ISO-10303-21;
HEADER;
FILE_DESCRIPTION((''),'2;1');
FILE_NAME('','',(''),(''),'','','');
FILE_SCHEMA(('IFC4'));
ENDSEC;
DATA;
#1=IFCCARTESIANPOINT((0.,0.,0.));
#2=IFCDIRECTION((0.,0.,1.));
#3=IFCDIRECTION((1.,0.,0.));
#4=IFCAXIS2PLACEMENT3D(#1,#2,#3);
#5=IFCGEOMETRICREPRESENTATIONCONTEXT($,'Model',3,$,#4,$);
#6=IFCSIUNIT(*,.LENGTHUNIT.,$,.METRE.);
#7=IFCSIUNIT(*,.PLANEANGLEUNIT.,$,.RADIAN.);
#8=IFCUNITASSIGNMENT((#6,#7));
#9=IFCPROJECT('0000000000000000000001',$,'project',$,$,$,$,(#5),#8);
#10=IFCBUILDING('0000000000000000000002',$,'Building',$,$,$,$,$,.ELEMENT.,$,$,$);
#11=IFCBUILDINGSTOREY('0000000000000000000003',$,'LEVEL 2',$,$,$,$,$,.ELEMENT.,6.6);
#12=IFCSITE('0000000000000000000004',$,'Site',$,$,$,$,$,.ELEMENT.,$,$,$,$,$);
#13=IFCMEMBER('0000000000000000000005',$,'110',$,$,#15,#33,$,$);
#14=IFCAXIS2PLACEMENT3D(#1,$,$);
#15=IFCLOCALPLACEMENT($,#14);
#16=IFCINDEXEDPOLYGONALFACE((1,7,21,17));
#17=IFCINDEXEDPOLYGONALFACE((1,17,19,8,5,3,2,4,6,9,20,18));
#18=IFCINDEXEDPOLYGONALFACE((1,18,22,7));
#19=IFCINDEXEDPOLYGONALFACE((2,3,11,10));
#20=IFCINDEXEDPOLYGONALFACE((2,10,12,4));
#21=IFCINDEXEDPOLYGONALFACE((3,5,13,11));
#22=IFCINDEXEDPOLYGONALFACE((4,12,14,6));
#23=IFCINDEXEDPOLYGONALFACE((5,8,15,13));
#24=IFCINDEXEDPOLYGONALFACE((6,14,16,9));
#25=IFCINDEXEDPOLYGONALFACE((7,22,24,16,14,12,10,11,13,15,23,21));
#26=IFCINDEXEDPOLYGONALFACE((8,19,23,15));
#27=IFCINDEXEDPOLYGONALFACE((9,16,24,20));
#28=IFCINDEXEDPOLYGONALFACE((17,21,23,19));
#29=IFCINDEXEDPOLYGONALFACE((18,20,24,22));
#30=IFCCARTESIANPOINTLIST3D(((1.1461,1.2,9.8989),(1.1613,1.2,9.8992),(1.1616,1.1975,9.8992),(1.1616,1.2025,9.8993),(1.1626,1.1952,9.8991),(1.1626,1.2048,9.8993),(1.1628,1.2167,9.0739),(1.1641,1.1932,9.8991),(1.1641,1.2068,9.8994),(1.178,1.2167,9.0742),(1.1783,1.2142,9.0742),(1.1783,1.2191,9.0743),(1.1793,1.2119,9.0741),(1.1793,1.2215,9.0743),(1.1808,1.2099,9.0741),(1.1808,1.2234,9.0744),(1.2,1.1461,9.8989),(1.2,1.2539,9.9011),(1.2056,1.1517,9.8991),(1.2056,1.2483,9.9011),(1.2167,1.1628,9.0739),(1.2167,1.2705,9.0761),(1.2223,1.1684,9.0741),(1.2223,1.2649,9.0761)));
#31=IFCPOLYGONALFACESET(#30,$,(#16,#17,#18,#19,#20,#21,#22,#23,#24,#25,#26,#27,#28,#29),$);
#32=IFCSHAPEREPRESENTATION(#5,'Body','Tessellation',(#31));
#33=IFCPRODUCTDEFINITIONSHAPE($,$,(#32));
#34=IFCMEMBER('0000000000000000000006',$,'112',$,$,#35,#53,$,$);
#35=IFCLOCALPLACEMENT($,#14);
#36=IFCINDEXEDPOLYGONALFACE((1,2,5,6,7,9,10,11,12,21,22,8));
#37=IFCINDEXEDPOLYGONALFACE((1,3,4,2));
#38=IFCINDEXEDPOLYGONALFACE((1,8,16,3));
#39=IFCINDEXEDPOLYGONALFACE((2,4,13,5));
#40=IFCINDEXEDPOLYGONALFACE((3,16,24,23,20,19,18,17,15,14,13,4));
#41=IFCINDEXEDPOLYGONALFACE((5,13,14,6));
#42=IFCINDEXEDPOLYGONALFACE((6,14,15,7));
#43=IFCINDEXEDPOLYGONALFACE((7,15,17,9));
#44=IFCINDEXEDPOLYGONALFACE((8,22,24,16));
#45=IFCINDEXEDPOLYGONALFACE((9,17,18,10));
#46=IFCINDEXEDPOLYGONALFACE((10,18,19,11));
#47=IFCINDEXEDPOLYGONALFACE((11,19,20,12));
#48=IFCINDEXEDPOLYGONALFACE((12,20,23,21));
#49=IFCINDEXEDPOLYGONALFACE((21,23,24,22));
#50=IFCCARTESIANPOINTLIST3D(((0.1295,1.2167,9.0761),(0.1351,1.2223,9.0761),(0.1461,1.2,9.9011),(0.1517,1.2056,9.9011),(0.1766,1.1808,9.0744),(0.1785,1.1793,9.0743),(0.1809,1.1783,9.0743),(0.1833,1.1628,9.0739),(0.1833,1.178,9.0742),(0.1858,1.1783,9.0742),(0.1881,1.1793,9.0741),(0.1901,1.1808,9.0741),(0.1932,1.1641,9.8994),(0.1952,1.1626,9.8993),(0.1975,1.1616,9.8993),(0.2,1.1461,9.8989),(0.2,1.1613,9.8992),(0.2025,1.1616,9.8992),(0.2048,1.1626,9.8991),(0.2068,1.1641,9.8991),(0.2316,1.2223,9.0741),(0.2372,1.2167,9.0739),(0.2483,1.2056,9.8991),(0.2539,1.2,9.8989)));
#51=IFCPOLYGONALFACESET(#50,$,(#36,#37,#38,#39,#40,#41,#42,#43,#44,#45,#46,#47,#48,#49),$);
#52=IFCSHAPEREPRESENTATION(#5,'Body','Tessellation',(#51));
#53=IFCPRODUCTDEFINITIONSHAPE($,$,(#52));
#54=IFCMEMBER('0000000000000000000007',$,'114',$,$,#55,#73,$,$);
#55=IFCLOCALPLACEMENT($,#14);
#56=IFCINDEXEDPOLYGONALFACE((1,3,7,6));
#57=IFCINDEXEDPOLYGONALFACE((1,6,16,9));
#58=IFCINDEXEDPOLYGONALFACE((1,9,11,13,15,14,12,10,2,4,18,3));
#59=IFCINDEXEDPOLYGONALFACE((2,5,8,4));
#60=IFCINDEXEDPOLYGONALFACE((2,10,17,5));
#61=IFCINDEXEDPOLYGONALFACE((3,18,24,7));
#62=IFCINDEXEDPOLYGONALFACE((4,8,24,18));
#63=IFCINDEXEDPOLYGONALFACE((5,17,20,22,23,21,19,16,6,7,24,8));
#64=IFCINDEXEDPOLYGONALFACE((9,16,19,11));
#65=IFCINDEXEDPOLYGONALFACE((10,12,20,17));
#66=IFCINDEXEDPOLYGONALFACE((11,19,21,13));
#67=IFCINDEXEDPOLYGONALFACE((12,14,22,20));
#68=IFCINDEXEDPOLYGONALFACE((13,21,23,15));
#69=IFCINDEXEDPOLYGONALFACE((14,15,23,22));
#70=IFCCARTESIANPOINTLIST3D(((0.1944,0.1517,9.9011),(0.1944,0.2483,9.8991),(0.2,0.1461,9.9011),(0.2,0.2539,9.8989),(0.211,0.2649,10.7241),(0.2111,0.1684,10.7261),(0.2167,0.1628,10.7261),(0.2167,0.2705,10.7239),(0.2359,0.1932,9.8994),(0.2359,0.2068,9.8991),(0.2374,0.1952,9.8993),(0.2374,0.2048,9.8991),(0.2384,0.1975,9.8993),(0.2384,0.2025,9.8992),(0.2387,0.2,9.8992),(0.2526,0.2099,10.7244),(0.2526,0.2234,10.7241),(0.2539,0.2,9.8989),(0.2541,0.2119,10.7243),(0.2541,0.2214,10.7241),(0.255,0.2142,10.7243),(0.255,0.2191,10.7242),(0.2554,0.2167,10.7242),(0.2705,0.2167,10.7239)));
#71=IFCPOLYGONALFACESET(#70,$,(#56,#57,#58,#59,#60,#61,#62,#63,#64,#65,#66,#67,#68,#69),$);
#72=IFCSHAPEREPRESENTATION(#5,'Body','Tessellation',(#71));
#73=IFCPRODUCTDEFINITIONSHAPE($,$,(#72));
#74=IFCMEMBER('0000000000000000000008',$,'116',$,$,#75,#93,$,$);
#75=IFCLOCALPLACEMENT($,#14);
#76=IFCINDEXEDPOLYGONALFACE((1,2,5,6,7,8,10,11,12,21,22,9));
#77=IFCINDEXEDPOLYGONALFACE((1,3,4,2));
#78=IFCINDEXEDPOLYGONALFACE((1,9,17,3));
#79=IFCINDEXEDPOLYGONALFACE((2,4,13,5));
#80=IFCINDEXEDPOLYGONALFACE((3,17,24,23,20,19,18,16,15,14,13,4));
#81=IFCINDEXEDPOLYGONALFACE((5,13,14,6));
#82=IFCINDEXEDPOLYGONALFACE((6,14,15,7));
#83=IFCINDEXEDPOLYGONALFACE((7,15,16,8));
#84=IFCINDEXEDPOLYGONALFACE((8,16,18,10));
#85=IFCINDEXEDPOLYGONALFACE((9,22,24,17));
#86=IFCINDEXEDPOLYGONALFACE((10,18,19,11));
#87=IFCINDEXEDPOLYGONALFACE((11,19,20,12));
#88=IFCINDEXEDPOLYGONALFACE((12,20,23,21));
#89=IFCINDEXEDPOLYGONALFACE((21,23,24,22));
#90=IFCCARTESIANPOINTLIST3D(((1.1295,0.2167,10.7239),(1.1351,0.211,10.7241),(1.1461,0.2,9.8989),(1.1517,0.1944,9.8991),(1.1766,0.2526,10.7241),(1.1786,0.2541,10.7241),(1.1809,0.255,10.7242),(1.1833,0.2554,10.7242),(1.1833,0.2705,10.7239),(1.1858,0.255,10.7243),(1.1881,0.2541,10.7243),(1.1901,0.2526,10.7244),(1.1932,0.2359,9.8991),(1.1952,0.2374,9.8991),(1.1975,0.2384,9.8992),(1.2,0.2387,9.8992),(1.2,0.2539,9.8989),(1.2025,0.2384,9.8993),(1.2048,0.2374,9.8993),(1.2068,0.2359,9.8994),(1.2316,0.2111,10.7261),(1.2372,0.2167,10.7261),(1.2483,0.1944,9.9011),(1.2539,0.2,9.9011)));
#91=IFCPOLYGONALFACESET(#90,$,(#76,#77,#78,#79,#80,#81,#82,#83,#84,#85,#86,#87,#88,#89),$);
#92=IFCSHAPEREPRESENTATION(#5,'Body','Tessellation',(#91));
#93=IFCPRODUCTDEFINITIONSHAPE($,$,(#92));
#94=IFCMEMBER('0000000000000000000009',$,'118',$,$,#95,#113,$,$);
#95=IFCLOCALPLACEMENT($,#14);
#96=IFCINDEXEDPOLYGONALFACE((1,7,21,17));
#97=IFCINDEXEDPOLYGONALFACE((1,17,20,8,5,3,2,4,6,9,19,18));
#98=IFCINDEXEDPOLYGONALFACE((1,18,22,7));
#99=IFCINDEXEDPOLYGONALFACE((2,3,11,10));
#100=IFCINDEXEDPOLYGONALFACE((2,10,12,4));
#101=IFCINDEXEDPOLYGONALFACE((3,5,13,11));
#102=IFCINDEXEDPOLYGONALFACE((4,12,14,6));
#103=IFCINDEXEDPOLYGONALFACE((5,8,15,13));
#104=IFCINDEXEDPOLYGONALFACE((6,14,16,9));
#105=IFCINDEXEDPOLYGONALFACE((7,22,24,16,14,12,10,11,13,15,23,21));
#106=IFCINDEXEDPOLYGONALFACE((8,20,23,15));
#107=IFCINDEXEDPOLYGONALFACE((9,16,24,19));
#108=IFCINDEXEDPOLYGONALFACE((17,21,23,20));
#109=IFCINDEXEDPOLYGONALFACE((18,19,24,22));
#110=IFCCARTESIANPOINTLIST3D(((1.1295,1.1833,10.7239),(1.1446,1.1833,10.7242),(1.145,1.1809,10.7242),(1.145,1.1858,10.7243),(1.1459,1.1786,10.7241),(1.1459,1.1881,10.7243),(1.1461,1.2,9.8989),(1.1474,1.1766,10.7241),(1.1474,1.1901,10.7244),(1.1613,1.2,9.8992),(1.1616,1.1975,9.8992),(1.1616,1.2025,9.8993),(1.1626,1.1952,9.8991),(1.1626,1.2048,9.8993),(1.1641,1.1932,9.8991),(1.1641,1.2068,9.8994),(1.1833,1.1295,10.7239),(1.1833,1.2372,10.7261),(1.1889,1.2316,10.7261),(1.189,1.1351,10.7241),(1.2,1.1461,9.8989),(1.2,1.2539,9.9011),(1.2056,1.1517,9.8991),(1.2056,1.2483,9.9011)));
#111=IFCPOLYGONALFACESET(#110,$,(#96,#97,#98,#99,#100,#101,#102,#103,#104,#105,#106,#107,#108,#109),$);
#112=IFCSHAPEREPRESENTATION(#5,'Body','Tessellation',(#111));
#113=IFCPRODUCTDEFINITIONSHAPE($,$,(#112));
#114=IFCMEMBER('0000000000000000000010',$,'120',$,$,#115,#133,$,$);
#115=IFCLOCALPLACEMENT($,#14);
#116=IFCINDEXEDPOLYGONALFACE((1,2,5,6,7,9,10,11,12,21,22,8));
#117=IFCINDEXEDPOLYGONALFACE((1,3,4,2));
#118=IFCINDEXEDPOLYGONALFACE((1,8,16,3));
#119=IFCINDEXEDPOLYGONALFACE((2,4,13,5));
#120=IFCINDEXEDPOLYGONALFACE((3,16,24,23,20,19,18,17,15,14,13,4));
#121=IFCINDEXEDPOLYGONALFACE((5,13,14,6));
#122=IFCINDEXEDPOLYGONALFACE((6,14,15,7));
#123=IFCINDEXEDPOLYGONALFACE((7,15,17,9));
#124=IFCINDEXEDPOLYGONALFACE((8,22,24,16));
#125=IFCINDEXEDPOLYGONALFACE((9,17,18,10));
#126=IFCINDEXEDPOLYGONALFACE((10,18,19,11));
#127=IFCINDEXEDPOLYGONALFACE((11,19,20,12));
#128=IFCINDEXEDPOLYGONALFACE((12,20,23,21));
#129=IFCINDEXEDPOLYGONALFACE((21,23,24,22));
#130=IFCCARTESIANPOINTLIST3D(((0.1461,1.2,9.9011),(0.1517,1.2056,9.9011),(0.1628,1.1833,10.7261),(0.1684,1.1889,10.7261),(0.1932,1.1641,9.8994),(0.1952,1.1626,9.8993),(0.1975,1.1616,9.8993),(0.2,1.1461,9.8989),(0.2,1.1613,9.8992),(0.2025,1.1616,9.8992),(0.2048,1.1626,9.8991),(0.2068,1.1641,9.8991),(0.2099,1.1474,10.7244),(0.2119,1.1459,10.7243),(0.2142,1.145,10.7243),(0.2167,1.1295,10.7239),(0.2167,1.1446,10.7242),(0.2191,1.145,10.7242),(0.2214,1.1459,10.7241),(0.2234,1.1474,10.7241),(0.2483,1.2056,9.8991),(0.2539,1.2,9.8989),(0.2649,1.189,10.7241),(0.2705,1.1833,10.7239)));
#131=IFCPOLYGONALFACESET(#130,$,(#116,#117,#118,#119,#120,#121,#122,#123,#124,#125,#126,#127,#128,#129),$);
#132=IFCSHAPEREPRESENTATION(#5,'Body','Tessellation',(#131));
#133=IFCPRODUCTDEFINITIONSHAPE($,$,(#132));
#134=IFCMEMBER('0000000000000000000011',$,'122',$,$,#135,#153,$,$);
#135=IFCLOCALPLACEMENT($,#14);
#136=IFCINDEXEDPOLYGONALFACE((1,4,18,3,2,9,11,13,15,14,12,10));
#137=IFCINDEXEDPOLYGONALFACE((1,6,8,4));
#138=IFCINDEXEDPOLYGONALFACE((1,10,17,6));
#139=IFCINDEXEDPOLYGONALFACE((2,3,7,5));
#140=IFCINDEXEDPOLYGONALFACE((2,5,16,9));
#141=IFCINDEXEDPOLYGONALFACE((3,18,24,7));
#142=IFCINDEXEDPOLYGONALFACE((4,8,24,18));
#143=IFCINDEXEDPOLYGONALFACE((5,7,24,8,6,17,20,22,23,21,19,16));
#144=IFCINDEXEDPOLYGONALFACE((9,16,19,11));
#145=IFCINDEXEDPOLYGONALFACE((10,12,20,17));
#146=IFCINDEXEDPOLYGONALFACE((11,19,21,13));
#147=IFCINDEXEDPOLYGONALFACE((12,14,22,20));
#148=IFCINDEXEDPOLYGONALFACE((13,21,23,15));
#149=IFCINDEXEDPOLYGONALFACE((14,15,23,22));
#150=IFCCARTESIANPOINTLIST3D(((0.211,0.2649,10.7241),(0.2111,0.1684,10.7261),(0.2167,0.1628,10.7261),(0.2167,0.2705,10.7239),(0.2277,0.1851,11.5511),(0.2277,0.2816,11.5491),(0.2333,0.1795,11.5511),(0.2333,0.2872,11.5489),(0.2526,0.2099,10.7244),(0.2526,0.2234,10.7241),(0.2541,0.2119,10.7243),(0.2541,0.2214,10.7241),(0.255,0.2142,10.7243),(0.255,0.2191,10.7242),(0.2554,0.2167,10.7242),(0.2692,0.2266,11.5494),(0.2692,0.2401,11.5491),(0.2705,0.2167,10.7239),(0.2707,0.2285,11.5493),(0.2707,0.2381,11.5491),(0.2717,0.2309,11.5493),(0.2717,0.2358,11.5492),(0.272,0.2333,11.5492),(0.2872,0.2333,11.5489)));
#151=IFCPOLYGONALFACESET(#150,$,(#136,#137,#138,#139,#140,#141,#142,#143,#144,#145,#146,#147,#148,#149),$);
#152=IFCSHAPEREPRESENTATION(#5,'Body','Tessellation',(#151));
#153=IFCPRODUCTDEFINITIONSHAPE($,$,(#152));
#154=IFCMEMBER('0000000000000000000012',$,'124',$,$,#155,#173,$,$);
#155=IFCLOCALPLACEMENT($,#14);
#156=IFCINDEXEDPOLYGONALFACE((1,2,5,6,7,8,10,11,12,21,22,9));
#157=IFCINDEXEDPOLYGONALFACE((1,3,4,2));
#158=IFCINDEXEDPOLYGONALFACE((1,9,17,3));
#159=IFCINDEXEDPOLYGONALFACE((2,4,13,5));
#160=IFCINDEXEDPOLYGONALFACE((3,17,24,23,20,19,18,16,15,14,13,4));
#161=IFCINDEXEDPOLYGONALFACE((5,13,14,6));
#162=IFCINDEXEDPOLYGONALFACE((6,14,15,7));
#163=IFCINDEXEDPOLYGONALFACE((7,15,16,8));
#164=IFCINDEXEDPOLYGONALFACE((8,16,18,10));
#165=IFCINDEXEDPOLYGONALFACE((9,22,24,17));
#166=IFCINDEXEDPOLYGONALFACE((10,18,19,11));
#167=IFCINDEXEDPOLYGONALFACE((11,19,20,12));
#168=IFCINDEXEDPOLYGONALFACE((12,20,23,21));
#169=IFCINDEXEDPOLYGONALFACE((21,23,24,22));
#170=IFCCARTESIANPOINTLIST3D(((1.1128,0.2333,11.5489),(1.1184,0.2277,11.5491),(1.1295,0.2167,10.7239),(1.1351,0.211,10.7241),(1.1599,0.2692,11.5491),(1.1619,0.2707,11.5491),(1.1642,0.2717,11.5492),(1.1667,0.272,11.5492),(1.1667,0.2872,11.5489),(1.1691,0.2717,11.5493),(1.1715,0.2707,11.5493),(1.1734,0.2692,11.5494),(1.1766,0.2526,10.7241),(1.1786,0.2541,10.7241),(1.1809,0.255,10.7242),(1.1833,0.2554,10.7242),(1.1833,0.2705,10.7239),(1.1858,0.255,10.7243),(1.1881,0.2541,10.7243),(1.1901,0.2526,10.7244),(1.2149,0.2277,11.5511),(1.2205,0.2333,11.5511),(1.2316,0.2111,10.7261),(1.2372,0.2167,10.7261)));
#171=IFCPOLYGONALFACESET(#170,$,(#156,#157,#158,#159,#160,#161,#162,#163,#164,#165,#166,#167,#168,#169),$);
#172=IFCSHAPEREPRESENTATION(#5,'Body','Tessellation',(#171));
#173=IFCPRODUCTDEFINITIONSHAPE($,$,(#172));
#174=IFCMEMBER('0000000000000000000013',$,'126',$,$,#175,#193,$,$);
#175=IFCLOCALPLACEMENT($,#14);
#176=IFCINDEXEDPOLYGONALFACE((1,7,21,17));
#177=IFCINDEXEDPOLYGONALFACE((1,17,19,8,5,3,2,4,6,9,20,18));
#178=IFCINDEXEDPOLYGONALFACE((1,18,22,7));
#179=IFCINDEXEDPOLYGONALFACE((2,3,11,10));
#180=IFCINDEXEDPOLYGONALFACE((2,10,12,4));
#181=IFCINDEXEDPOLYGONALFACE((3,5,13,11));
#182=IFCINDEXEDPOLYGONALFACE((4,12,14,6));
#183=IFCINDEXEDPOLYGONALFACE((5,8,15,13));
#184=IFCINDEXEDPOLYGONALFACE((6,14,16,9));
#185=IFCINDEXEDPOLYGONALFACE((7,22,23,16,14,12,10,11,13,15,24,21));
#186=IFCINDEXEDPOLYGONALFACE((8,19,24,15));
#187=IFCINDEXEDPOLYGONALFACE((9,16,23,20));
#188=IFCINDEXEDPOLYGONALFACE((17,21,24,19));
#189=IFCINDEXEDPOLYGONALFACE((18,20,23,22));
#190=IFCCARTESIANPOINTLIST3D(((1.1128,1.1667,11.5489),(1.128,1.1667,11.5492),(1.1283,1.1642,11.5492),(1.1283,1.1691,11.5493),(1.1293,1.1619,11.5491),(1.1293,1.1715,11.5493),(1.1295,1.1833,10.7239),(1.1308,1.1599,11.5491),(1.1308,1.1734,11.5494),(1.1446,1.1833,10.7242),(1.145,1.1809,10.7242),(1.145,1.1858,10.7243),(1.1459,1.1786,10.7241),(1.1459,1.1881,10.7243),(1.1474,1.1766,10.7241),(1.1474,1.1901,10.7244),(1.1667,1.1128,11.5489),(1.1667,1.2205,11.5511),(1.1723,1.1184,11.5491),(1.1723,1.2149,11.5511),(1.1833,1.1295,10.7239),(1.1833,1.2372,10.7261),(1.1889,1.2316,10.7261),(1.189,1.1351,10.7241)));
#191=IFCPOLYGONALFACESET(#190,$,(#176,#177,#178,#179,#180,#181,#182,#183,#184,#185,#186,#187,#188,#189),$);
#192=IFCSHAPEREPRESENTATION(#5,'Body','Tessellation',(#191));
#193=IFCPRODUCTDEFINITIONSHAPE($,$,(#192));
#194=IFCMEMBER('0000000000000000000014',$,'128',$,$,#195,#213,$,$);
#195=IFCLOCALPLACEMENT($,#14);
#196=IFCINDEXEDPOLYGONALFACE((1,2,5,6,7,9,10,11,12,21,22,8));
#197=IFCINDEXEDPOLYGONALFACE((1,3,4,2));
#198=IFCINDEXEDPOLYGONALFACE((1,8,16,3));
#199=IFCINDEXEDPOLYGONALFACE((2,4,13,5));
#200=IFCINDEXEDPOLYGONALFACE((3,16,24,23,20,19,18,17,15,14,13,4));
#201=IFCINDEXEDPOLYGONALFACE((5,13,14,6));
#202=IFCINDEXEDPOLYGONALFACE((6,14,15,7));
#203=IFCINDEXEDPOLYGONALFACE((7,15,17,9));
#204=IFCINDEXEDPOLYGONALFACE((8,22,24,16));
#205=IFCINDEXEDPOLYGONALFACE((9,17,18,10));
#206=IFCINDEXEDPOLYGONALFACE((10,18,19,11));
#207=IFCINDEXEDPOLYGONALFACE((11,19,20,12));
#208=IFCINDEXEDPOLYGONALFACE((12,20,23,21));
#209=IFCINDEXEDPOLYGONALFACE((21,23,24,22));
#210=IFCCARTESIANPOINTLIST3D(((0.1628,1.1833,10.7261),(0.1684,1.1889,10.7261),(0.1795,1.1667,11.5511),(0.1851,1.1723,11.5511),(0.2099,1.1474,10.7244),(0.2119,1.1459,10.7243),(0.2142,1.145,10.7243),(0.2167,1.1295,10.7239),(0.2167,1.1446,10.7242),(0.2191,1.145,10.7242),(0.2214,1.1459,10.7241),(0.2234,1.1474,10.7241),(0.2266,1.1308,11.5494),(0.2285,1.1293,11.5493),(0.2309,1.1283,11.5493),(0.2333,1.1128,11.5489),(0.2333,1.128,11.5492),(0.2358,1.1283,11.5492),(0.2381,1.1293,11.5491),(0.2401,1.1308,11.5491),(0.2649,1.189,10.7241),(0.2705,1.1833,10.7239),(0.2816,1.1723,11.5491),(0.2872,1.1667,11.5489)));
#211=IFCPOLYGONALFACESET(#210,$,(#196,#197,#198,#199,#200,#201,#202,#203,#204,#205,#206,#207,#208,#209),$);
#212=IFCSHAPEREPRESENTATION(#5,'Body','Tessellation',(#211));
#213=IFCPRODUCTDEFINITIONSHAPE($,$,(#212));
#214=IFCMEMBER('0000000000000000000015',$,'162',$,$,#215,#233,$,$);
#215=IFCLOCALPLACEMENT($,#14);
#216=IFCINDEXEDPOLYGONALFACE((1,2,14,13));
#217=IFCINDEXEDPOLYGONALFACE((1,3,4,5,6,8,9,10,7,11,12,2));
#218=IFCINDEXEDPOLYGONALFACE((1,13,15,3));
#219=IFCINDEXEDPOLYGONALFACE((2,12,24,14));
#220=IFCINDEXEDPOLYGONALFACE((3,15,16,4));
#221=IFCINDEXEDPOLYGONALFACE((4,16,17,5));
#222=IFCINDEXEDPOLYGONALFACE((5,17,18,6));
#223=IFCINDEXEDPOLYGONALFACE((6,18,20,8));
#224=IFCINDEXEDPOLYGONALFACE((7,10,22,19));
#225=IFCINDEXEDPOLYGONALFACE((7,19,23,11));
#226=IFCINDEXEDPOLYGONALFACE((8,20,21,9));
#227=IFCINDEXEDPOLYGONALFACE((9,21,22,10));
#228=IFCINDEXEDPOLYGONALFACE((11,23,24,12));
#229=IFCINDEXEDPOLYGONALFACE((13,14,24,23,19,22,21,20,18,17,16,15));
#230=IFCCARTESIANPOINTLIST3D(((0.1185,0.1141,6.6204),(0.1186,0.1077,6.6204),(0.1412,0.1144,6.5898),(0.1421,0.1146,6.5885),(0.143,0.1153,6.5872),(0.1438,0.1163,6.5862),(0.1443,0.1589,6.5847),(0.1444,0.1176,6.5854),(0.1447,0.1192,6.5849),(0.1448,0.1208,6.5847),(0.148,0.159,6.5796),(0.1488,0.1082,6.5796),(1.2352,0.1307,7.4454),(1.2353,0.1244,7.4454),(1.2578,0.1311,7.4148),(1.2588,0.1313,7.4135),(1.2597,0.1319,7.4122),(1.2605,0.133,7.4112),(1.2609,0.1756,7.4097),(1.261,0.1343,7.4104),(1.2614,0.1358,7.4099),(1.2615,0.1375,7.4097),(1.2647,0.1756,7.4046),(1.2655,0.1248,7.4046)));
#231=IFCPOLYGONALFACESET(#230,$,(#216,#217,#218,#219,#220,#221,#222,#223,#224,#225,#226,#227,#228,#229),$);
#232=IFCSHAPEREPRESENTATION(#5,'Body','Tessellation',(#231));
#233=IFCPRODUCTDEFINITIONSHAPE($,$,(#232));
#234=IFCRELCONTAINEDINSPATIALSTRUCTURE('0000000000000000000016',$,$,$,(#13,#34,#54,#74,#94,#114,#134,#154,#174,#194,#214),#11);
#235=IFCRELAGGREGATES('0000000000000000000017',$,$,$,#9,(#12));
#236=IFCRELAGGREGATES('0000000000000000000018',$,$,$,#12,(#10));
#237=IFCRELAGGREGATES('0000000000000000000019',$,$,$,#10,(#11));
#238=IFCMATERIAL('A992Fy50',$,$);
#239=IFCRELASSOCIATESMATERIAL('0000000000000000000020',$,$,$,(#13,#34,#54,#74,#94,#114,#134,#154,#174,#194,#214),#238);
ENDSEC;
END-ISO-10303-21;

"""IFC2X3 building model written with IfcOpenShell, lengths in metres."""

from ifc_helpers import new_model, si_unit, frame, origin_with_axes, origin_2d_with_axis, place, context, project, spatial, l_section, extrude, material, element, save


model = new_model("IFC2X3")

# Units and contexts
model_context = context("Model", 3, world=origin_with_axes())
ifc_project = project(units=[si_unit("LENGTHUNIT", "METRE"), si_unit("PLANEANGLEUNIT", "RADIAN")], contexts=[model_context])

# Site, building, storey
site = spatial("IfcSite", under=ifc_project, Name="Site", CompositionType="ELEMENT")
building = spatial("IfcBuilding", under=site, Name="Building", CompositionType="ELEMENT")
storey = spatial("IfcBuildingStorey", under=building, Name="LEVEL 2", CompositionType="ELEMENT", Elevation=6.6)

# Shared definitions
ifc_material = material(Name="A992Fy50")

# Members
for number, where, z_axis, x_axis, name in (
    (1, (1.2167, 1.2167, 9.075), (-0.020194, -0.020194, 0.999592), (0.707107, -0.707107, 0.0), "110"),
    (2, (0.1833, 1.2167, 9.075), (0.020194, -0.020194, 0.999592), (0.707107, 0.707107, 0.0), "112"),
    (3, (0.2, 0.2, 9.9), (0.020194, 0.020194, 0.999592), (-0.707107, 0.707107, 0.0), "114"),
    (4, (1.2, 0.2, 9.9), (-0.020194, 0.020194, 0.999592), (-0.707107, -0.707107, 0.0), "116"),
    (5, (1.2, 1.2, 9.9), (-0.020194, -0.020194, 0.999592), (0.707107, -0.707107, 0.0), "118"),
    (6, (0.2, 1.2, 9.9), (0.020194, -0.020194, 0.999592), (0.707107, 0.707107, 0.0), "120"),
    (7, (0.2167, 0.2167, 10.725), (0.020194, 0.020194, 0.999592), (-0.707107, 0.707107, 0.0), "122"),
    (8, (1.1833, 0.2167, 10.725), (-0.020194, 0.020194, 0.999592), (-0.707107, -0.707107, 0.0), "124"),
    (9, (1.1833, 1.1833, 10.725), (-0.020194, -0.020194, 0.999592), (0.707107, -0.707107, 0.0), "126"),
    (10, (0.2167, 1.1833, 10.725), (0.020194, -0.020194, 0.999592), (0.707107, 0.707107, 0.0), "128"),
):
    element("IfcMember", number, at=place(None, frame(where, z_axis=z_axis, x_axis=x_axis)), inside=storey, material=ifc_material, Name=name, context=model_context, shape_type="SweptSolid", body=[
        extrude(l_section(Depth=0.0762, Width=0.0762, Thickness=0.0079, FilletRadius=0.0096, at=origin_2d_with_axis()), origin_with_axes(), (0.0, 0.0, 1.0), 0.8253),
    ])
member_1_placement = place(None, frame((0.1333, 0.1333, 6.6), z_axis=(0.804243, 0.012004, 0.594179), x_axis=(-0.014924, 0.999889, 0.0)))
element("IfcMember", 11, at=member_1_placement, inside=storey, material=ifc_material, Name="162", context=model_context, shape_type="SweptSolid", body=[
    extrude(l_section(Depth=0.0508, Width=0.0508, Thickness=0.0063, FilletRadius=0.0063, at=origin_2d_with_axis()), origin_with_axes(), (0.0, 0.0, 1.0), 1.3885),
])

save(model, "model.ifc")
